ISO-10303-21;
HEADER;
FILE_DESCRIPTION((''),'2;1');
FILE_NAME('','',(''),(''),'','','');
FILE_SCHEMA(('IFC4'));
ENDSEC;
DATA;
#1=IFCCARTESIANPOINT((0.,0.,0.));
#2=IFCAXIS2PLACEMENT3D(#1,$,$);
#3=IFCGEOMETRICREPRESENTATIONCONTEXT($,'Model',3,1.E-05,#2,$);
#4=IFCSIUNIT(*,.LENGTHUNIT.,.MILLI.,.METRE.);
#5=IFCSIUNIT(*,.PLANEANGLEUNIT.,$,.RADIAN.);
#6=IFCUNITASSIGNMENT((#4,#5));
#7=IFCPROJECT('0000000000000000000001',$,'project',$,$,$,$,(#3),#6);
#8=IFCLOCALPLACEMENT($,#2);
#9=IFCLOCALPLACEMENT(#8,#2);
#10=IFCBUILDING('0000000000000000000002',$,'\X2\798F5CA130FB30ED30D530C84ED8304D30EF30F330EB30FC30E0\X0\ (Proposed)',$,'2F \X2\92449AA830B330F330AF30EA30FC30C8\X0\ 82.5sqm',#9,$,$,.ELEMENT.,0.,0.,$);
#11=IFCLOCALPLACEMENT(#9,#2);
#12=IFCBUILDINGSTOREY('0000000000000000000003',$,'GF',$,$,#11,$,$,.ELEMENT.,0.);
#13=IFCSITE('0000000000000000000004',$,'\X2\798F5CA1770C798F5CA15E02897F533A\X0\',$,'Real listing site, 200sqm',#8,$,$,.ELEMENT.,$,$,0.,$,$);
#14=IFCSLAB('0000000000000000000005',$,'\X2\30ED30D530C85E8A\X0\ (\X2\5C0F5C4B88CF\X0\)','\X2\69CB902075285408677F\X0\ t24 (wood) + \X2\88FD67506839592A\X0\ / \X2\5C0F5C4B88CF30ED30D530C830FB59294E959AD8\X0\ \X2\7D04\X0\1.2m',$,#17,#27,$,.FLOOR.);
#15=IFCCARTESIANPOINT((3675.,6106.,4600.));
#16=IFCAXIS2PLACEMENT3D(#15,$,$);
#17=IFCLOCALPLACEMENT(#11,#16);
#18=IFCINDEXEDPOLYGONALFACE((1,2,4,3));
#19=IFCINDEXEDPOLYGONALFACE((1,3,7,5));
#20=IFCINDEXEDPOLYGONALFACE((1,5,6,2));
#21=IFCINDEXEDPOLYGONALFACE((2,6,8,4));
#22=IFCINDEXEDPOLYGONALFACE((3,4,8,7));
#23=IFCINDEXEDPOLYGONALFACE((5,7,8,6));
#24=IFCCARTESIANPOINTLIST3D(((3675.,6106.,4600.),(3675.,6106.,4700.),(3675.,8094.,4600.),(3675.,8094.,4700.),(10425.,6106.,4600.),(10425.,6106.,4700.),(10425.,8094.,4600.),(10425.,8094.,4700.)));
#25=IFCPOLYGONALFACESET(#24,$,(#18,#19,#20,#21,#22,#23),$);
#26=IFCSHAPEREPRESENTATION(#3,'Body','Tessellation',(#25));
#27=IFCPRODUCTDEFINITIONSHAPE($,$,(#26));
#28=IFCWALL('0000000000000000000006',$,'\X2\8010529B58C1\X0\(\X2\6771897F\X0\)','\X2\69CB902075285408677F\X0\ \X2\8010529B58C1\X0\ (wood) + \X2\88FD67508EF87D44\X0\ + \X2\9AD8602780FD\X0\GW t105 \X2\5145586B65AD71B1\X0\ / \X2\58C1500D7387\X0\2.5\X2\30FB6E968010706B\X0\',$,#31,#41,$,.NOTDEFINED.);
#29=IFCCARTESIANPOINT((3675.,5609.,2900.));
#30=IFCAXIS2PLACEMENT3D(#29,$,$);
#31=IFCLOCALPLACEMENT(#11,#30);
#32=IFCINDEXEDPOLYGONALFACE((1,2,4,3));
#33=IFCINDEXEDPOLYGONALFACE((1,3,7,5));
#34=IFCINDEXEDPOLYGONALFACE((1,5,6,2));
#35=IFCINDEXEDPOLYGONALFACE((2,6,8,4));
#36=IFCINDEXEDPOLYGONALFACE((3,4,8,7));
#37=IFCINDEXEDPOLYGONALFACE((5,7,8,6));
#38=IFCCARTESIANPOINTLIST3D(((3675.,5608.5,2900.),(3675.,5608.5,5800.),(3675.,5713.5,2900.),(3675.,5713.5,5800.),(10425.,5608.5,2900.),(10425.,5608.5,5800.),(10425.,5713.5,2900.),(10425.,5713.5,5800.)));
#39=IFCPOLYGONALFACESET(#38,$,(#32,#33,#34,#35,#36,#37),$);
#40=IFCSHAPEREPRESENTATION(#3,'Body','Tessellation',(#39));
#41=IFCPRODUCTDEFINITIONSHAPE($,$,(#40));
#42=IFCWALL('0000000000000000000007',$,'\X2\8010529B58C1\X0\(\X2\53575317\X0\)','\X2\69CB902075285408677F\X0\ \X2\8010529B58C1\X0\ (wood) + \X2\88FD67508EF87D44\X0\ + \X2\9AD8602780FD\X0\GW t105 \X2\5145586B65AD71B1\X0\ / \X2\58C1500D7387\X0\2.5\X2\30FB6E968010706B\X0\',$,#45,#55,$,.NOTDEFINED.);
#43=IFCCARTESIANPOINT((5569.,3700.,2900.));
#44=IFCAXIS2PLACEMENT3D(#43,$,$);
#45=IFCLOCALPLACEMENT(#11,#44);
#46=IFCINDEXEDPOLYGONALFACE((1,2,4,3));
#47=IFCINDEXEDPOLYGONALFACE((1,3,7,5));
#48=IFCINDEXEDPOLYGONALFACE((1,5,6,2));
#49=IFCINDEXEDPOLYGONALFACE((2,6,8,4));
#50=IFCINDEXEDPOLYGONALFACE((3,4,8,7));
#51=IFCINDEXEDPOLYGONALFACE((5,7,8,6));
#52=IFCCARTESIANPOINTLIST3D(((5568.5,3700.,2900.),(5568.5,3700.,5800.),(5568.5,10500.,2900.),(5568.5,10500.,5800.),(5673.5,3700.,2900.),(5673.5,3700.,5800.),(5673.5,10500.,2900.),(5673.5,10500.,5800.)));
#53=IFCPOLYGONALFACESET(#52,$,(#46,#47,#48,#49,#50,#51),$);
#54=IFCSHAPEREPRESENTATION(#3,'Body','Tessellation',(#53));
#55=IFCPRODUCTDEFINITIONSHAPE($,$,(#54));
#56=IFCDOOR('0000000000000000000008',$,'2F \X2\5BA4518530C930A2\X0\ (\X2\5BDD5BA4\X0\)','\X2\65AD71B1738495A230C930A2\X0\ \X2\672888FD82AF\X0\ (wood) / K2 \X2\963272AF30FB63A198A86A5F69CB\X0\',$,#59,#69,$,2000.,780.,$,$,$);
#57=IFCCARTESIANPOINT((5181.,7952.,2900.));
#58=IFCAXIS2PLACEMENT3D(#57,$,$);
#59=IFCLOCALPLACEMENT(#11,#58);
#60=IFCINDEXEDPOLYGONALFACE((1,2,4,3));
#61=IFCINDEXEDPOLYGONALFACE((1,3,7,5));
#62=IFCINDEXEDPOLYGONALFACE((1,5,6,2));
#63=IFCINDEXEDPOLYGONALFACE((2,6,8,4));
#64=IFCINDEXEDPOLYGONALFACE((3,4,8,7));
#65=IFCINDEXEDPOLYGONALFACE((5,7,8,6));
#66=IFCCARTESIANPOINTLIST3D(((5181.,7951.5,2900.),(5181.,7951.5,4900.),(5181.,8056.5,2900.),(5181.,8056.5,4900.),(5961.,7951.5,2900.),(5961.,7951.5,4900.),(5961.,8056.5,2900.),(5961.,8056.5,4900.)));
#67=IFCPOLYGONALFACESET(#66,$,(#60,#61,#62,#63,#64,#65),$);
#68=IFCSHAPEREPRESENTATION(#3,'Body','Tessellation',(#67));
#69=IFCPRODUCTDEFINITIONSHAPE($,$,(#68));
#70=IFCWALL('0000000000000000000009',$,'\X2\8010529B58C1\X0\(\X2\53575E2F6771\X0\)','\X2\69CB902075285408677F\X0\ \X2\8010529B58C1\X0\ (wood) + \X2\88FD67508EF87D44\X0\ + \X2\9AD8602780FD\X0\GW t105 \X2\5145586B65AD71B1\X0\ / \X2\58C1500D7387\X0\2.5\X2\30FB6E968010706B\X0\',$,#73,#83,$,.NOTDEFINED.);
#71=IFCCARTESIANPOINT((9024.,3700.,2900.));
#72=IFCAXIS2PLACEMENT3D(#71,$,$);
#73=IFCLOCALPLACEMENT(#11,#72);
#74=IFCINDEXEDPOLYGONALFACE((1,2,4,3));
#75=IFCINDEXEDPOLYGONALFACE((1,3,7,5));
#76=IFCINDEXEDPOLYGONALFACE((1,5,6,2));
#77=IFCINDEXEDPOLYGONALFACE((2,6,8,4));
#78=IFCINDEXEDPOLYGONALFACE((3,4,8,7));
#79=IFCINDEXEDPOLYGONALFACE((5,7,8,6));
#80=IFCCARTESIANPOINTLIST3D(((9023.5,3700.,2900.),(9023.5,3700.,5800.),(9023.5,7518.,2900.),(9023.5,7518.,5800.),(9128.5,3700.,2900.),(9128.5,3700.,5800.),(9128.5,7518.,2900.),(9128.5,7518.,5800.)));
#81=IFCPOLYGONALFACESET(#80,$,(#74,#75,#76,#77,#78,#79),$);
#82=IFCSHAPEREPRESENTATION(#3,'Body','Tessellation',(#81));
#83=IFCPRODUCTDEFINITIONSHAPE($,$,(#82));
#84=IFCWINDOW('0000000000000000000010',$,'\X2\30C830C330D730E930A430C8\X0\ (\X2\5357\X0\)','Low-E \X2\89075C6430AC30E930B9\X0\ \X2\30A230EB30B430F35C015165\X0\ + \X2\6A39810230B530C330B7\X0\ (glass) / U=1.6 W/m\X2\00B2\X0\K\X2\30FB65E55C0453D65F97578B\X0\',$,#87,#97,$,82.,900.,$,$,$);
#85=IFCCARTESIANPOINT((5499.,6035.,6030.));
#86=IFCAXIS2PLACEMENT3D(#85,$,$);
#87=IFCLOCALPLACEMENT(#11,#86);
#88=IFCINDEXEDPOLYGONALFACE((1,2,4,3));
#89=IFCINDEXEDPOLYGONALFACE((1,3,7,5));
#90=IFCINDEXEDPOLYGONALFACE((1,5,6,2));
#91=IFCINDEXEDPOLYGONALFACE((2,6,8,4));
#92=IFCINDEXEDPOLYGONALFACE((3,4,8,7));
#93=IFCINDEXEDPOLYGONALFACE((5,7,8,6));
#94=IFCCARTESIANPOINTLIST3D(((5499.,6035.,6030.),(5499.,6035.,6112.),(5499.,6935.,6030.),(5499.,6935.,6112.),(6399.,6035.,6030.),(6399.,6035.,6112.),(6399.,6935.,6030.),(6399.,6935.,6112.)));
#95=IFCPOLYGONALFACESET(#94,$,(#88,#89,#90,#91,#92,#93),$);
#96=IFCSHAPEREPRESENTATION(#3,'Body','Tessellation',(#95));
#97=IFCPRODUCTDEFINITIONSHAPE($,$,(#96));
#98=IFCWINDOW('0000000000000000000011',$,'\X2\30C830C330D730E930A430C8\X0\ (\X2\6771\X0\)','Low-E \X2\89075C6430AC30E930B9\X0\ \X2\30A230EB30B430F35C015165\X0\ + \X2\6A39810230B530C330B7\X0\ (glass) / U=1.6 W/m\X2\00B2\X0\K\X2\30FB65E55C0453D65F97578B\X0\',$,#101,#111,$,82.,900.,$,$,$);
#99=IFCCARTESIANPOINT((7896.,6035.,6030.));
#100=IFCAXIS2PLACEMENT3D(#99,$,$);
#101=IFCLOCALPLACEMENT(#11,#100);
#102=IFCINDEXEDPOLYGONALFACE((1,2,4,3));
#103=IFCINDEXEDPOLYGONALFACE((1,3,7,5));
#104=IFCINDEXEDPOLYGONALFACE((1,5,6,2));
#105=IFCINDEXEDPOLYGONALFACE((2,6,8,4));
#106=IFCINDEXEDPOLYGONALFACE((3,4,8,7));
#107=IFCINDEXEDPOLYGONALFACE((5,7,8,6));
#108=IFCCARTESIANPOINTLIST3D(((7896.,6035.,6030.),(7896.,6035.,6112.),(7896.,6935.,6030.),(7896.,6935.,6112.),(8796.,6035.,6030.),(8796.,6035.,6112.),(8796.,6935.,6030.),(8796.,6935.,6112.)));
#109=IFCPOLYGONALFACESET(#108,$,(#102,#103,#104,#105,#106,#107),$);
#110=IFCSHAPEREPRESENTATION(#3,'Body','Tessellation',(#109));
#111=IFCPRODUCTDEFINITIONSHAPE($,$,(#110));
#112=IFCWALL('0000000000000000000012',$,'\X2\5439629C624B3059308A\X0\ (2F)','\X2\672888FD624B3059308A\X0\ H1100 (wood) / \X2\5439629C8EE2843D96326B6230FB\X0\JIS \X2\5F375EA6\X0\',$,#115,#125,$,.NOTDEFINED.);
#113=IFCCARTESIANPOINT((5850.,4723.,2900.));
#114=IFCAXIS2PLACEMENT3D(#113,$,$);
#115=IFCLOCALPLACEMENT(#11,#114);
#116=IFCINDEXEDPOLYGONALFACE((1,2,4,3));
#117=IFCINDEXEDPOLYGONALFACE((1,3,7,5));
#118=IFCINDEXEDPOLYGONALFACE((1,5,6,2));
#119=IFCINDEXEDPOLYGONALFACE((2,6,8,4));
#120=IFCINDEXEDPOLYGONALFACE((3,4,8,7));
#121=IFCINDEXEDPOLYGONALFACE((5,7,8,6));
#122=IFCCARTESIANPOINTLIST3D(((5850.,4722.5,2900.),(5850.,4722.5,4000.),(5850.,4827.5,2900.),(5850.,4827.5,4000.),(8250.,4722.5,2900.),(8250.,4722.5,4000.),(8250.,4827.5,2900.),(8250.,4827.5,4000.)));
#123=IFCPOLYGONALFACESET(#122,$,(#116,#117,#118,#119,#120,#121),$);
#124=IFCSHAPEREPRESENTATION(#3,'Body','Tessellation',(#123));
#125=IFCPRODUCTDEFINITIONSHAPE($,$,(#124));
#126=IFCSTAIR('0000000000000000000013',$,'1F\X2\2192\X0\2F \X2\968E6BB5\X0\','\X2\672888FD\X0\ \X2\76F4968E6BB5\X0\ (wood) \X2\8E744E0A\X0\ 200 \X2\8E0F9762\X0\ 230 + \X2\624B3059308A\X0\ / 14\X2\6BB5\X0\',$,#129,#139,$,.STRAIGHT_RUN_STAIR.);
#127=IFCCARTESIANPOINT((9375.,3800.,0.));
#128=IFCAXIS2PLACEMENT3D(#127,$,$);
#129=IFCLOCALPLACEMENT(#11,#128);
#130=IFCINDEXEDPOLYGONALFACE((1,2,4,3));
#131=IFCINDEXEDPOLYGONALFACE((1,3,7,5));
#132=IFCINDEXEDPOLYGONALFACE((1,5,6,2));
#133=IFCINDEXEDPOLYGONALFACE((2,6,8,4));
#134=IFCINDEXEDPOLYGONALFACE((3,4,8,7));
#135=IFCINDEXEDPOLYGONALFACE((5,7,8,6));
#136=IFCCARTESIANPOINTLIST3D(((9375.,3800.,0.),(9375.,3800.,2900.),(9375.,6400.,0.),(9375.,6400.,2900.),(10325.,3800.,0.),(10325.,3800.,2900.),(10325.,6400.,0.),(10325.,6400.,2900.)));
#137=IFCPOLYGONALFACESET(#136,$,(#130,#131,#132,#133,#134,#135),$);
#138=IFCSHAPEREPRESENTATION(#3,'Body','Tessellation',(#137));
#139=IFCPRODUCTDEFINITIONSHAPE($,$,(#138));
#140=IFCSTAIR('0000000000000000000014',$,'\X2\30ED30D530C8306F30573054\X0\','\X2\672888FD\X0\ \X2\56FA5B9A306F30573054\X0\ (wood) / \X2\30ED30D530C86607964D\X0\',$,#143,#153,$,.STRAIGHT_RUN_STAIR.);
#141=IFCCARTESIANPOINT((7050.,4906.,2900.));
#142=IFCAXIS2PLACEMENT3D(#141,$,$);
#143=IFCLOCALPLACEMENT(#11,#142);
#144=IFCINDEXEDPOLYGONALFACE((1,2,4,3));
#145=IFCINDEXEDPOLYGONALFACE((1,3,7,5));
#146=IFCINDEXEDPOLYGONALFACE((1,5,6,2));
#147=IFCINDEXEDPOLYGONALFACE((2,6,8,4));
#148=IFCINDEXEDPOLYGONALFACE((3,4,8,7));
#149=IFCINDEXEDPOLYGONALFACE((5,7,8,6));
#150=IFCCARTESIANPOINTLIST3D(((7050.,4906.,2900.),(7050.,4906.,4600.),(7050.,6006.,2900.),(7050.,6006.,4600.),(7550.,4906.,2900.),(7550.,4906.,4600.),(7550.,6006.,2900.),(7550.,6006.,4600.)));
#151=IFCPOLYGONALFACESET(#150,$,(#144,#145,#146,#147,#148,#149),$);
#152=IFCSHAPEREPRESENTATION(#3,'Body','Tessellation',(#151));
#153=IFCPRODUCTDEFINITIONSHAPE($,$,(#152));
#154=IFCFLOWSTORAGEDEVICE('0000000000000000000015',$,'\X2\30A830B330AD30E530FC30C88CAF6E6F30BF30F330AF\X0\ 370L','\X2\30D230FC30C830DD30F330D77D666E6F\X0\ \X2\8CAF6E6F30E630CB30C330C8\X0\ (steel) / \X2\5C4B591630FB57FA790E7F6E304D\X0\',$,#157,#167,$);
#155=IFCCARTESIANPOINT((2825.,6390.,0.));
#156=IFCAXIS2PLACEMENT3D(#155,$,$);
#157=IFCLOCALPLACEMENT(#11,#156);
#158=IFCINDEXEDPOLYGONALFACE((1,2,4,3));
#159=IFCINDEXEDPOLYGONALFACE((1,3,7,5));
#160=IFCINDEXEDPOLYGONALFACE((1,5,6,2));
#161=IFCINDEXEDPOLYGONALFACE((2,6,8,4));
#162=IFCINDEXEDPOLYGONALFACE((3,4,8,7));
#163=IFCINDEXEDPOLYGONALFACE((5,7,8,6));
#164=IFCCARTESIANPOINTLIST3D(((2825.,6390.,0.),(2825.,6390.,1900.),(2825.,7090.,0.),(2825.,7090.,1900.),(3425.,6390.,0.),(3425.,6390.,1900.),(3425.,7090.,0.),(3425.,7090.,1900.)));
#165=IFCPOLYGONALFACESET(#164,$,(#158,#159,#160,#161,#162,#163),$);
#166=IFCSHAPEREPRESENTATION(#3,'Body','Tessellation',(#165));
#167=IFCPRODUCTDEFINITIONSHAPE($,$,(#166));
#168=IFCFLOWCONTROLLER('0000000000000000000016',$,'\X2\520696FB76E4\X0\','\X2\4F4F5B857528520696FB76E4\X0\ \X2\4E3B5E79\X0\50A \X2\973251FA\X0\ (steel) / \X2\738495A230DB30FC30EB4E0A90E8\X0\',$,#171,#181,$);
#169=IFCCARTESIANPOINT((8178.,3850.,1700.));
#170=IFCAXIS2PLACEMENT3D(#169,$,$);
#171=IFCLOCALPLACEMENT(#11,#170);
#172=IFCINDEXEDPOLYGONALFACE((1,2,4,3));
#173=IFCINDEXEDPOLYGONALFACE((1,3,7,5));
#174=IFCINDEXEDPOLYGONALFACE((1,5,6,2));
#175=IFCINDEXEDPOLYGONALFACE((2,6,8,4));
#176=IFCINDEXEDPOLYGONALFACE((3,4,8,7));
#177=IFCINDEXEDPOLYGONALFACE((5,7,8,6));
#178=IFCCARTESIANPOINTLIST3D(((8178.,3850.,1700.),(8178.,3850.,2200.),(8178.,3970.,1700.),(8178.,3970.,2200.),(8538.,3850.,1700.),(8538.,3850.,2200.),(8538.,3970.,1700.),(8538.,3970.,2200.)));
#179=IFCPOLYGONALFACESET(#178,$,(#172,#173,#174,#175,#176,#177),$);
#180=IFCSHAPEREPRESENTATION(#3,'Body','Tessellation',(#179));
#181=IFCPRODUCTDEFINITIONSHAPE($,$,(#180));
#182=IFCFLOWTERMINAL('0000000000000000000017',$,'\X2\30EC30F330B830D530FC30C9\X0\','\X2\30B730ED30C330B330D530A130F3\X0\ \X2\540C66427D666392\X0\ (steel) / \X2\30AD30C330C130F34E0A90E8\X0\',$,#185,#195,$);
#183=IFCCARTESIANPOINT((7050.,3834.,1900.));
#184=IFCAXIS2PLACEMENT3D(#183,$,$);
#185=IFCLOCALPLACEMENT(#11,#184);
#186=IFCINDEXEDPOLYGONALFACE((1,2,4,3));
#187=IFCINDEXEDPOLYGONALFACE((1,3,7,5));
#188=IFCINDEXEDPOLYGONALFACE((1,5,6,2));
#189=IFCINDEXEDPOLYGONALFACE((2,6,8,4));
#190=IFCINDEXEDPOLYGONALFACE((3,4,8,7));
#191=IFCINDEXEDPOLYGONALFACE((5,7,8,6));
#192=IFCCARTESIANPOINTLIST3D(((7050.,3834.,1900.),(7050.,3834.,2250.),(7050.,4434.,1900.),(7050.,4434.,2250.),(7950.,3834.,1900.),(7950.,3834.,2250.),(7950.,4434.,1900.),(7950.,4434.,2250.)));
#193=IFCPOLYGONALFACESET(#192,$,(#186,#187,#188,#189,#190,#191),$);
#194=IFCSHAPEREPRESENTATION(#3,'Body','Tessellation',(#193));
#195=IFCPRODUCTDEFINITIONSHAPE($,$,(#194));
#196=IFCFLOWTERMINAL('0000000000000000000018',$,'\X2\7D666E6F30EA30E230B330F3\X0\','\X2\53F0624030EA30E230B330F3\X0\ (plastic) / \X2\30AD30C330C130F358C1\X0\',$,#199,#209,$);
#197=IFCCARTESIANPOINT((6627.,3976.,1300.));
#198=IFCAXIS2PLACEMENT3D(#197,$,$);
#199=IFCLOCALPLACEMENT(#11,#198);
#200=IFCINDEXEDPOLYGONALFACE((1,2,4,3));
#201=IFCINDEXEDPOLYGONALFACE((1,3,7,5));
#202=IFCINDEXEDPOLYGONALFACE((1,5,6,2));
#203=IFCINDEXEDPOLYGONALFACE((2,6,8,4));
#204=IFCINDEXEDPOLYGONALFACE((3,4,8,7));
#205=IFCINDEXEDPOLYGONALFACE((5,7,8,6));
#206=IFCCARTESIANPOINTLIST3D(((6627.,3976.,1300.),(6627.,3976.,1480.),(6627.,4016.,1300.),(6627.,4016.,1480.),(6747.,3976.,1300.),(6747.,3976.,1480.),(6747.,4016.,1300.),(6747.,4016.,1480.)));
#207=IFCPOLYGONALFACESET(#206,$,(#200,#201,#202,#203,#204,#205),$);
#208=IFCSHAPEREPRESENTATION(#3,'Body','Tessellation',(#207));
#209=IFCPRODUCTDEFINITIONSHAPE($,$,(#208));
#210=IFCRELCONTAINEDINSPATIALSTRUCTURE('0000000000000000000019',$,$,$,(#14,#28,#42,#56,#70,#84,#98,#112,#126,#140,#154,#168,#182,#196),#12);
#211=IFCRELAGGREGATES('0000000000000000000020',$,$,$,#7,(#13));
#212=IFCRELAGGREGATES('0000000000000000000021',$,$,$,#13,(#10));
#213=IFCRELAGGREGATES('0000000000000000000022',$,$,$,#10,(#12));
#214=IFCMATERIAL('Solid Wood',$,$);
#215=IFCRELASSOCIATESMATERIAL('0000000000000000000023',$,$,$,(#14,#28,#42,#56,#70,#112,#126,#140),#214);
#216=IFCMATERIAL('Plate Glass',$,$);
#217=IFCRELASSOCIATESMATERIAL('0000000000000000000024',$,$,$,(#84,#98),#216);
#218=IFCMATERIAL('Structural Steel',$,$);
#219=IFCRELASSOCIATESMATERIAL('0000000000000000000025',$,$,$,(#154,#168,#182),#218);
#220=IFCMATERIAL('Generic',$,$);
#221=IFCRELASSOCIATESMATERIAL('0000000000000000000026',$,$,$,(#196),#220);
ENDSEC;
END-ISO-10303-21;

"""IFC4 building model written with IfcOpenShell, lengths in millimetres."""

from ifc_helpers import new_model, si_unit, frame, frame_2d, origin, place, context, project, spatial, rectangle, extrude, material, element, fill, save


model = new_model("IFC4")

# Units and contexts
model_context = context("Model", 3, precision=1e-05, world=origin())
ifc_project = project(units=[si_unit("LENGTHUNIT", "METRE", prefix="MILLI"), si_unit("PLANEANGLEUNIT", "RADIAN")], contexts=[model_context])

# Site, building, storey
site_placement = place(None, origin())
site = spatial("IfcSite", under=ifc_project, at=site_placement, Name="福岡県福岡市西区", ObjectType="Real listing site, 200sqm", CompositionType="ELEMENT", RefElevation=0.0)
building_placement = place(site_placement, origin())
building = spatial("IfcBuilding", under=site, at=building_placement, Name="福岡・ロフト付きワンルーム (Proposed)", ObjectType="2F 鉄骨コンクリート 82.5sqm", CompositionType="ELEMENT", ElevationOfRefHeight=0.0, ElevationOfTerrain=0.0)
storey_placement = place(building_placement, origin())
storey = spatial("IfcBuildingStorey", under=building, at=storey_placement, Name="GF", CompositionType="ELEMENT", Elevation=0.0)

# Shared definitions
ifc_material_1 = material(Name="Solid Wood")

# Slab
slab_placement = place(storey_placement, frame((3675.0, 6106.0, 4600.0)))
element("IfcSlab", 1, at=slab_placement, inside=storey, material=ifc_material_1, Name="ロフト床 (小屋裏)", Description="構造用合板 t24 (wood) + 製材根太 / 小屋裏ロフト・天井高 約1.2m", PredefinedType="FLOOR", context=model_context, shape_type="SweptSolid", body=[
    extrude(rectangle(XDim=6750.0, YDim=1988.0, at=frame_2d((3375.0, 994.0))), frame((3675.0, 6106.0, 4600.0)), (0.0, 0.0, 1.0), 100.0),
])

# Wall
wall_1_placement = place(storey_placement, frame((3675.0, 5609.0, 2900.0)))
element("IfcWall", 2, at=wall_1_placement, inside=storey, material=ifc_material_1, Name="耐力壁(東西)", Description="構造用合板 耐力壁 (wood) + 製材軸組 + 高性能GW t105 充填断熱 / 壁倍率2.5・準耐火", PredefinedType="NOTDEFINED", context=model_context, shape_type="SweptSolid", body=[
    extrude(rectangle(XDim=6750.0, YDim=105.0, at=frame_2d((3375.0, 52.0))), frame((3675.0, 5609.0, 2900.0)), (0.0, 0.0, 1.0), 2900.0),
])

# Wall, opening, door
wall_2_placement = place(storey_placement, frame((5569.0, 3700.0, 2900.0)))
wall_2 = element("IfcWall", 3, at=wall_2_placement, inside=storey, material=ifc_material_1, Name="耐力壁(南北)", Description="構造用合板 耐力壁 (wood) + 製材軸組 + 高性能GW t105 充填断熱 / 壁倍率2.5・準耐火", PredefinedType="NOTDEFINED", context=model_context, shape_type="SweptSolid", body=[
    extrude(rectangle(XDim=105.0, YDim=6800.0, at=frame_2d((52.0, 3400.0))), frame((5569.0, 3700.0, 2900.0)), (0.0, 0.0, 1.0), 2900.0),
])
opening_placement = place(storey_placement, frame((5181.0, 7952.0, 2900.0)))
opening = element("IfcOpeningElement", 4, at=opening_placement, cuts=wall_2, PredefinedType="NOTDEFINED", context=model_context, shape_type="SweptSolid", body=[
    extrude(rectangle(XDim=780.0, YDim=105.0, at=frame_2d((390.0, 52.0))), frame((5181.0, 7952.0, 2900.0)), (0.0, 0.0, 1.0), 2000.0),
])
door_placement = place(storey_placement, frame((5181.0, 7952.0, 2900.0)))
door = element("IfcDoor", 5, at=door_placement, inside=storey, material=ifc_material_1, Name="2F 室内ドア (寝室)", Description="断熱玄関ドア 木製芯 (wood) / K2 防犯・採風機構", OverallHeight=2000.0, OverallWidth=780.0, context=model_context, shape_type="SweptSolid", body=[
    extrude(rectangle(XDim=780.0, YDim=105.0, at=frame_2d((390.0, 52.0))), frame((5181.0, 7952.0, 2900.0)), (0.0, 0.0, 1.0), 2000.0),
])
fill(opening, door)

# Wall
wall_3_placement = place(storey_placement, frame((9024.0, 3700.0, 2900.0)))
element("IfcWall", 6, at=wall_3_placement, inside=storey, material=ifc_material_1, Name="耐力壁(南帯東)", Description="構造用合板 耐力壁 (wood) + 製材軸組 + 高性能GW t105 充填断熱 / 壁倍率2.5・準耐火", PredefinedType="NOTDEFINED", context=model_context, shape_type="SweptSolid", body=[
    extrude(rectangle(XDim=105.0, YDim=3818.0, at=frame_2d((52.0, 1909.0))), frame((9024.0, 3700.0, 2900.0)), (0.0, 0.0, 1.0), 2900.0),
])

# Windows
ifc_material_2 = material(Name="Plate Glass")
window_1_placement = place(storey_placement, frame((5499.0, 6035.0, 6030.0)))
element("IfcWindow", 7, at=window_1_placement, inside=storey, material=ifc_material_2, Name="トップライト (南)", Description="Low-E 複層ガラス アルゴン封入 + 樹脂サッシ (glass) / U=1.6 W/m²K・日射取得型", OverallHeight=82.0, OverallWidth=900.0, context=model_context, shape_type="SweptSolid", body=[
    extrude(rectangle(XDim=900.0, YDim=900.0, at=frame_2d((450.0, 450.0))), frame((5499.0, 6035.0, 6030.0)), (0.0, 0.0, 1.0), 82.0),
])
window_2_placement = place(storey_placement, frame((7896.0, 6035.0, 6030.0)))
element("IfcWindow", 8, at=window_2_placement, inside=storey, material=ifc_material_2, Name="トップライト (東)", Description="Low-E 複層ガラス アルゴン封入 + 樹脂サッシ (glass) / U=1.6 W/m²K・日射取得型", OverallHeight=82.0, OverallWidth=900.0, context=model_context, shape_type="SweptSolid", body=[
    extrude(rectangle(XDim=900.0, YDim=900.0, at=frame_2d((450.0, 450.0))), frame((7896.0, 6035.0, 6030.0)), (0.0, 0.0, 1.0), 82.0),
])

# Wall
wall_4_placement = place(storey_placement, frame((5850.0, 4723.0, 2900.0)))
element("IfcWall", 9, at=wall_4_placement, inside=storey, material=ifc_material_1, Name="吹抜手すり (2F)", Description="木製手すり H1100 (wood) / 吹抜転落防止・JIS 強度", PredefinedType="NOTDEFINED", context=model_context, shape_type="SweptSolid", body=[
    extrude(rectangle(XDim=2400.0, YDim=105.0, at=frame_2d((1200.0, 52.0))), frame((5850.0, 4723.0, 2900.0)), (0.0, 0.0, 1.0), 1100.0),
])

# Stairs
stair_1_placement = place(storey_placement, frame((9375.0, 3800.0, 0.0)))
element("IfcStair", 10, at=stair_1_placement, inside=storey, material=ifc_material_1, Name="1F→2F 階段", Description="木製 直階段 (wood) 蹴上 200 踏面 230 + 手すり / 14段", PredefinedType="STRAIGHT_RUN_STAIR", context=model_context, shape_type="SweptSolid", body=[
    extrude(rectangle(XDim=950.0, YDim=2600.0, at=frame_2d((475.0, 1300.0))), frame((9375.0, 3800.0, 0.0)), (0.0, 0.0, 1.0), 2900.0),
])
stair_2_placement = place(storey_placement, frame((7050.0, 4906.0, 2900.0)))
element("IfcStair", 11, at=stair_2_placement, inside=storey, material=ifc_material_1, Name="ロフトはしご", Description="木製 固定はしご (wood) / ロフト昇降", PredefinedType="STRAIGHT_RUN_STAIR", context=model_context, shape_type="SweptSolid", body=[
    extrude(rectangle(XDim=500.0, YDim=1100.0, at=frame_2d((250.0, 550.0))), frame((7050.0, 4906.0, 2900.0)), (0.0, 0.0, 1.0), 1700.0),
])

# Flow storage device
ifc_material_3 = material(Name="Structural Steel")
flow_storage_device_placement = place(storey_placement, frame((2825.0, 6390.0, 0.0)))
element("IfcFlowStorageDevice", 12, at=flow_storage_device_placement, inside=storey, material=ifc_material_3, Name="エコキュート貯湯タンク 370L", Description="ヒートポンプ給湯 貯湯ユニット (steel) / 屋外・基礎置き", context=model_context, shape_type="SweptSolid", body=[
    extrude(rectangle(XDim=600.0, YDim=700.0, at=frame_2d((300.0, 350.0))), frame((2825.0, 6390.0, 0.0)), (0.0, 0.0, 1.0), 1900.0),
])

# Flow controller
flow_controller_placement = place(storey_placement, frame((8178.0, 3850.0, 1700.0)))
element("IfcFlowController", 13, at=flow_controller_placement, inside=storey, material=ifc_material_3, Name="分電盤", Description="住宅用分電盤 主幹50A 露出 (steel) / 玄関ホール上部", context=model_context, shape_type="SweptSolid", body=[
    extrude(rectangle(XDim=360.0, YDim=120.0, at=frame_2d((180.0, 60.0))), frame((8178.0, 3850.0, 1700.0)), (0.0, 0.0, 1.0), 500.0),
])

# Flow terminals
flow_terminal_1_placement = place(storey_placement, frame((7050.0, 3834.0, 1900.0)))
element("IfcFlowTerminal", 14, at=flow_terminal_1_placement, inside=storey, material=ifc_material_3, Name="レンジフード", Description="シロッコファン 同時給排 (steel) / キッチン上部", context=model_context, shape_type="SweptSolid", body=[
    extrude(rectangle(XDim=900.0, YDim=600.0, at=frame_2d((450.0, 300.0))), frame((7050.0, 3834.0, 1900.0)), (0.0, 0.0, 1.0), 350.0),
])
ifc_material_4 = material(Name="Generic")
flow_terminal_2_placement = place(storey_placement, frame((6627.0, 3976.0, 1300.0)))
element("IfcFlowTerminal", 15, at=flow_terminal_2_placement, inside=storey, material=ifc_material_4, Name="給湯リモコン", Description="台所リモコン (plastic) / キッチン壁", context=model_context, shape_type="SweptSolid", body=[
    extrude(rectangle(XDim=120.0, YDim=40.0, at=frame_2d((60.0, 20.0))), frame((6627.0, 3976.0, 1300.0)), (0.0, 0.0, 1.0), 180.0),
])

save(model, "model.ifc")
